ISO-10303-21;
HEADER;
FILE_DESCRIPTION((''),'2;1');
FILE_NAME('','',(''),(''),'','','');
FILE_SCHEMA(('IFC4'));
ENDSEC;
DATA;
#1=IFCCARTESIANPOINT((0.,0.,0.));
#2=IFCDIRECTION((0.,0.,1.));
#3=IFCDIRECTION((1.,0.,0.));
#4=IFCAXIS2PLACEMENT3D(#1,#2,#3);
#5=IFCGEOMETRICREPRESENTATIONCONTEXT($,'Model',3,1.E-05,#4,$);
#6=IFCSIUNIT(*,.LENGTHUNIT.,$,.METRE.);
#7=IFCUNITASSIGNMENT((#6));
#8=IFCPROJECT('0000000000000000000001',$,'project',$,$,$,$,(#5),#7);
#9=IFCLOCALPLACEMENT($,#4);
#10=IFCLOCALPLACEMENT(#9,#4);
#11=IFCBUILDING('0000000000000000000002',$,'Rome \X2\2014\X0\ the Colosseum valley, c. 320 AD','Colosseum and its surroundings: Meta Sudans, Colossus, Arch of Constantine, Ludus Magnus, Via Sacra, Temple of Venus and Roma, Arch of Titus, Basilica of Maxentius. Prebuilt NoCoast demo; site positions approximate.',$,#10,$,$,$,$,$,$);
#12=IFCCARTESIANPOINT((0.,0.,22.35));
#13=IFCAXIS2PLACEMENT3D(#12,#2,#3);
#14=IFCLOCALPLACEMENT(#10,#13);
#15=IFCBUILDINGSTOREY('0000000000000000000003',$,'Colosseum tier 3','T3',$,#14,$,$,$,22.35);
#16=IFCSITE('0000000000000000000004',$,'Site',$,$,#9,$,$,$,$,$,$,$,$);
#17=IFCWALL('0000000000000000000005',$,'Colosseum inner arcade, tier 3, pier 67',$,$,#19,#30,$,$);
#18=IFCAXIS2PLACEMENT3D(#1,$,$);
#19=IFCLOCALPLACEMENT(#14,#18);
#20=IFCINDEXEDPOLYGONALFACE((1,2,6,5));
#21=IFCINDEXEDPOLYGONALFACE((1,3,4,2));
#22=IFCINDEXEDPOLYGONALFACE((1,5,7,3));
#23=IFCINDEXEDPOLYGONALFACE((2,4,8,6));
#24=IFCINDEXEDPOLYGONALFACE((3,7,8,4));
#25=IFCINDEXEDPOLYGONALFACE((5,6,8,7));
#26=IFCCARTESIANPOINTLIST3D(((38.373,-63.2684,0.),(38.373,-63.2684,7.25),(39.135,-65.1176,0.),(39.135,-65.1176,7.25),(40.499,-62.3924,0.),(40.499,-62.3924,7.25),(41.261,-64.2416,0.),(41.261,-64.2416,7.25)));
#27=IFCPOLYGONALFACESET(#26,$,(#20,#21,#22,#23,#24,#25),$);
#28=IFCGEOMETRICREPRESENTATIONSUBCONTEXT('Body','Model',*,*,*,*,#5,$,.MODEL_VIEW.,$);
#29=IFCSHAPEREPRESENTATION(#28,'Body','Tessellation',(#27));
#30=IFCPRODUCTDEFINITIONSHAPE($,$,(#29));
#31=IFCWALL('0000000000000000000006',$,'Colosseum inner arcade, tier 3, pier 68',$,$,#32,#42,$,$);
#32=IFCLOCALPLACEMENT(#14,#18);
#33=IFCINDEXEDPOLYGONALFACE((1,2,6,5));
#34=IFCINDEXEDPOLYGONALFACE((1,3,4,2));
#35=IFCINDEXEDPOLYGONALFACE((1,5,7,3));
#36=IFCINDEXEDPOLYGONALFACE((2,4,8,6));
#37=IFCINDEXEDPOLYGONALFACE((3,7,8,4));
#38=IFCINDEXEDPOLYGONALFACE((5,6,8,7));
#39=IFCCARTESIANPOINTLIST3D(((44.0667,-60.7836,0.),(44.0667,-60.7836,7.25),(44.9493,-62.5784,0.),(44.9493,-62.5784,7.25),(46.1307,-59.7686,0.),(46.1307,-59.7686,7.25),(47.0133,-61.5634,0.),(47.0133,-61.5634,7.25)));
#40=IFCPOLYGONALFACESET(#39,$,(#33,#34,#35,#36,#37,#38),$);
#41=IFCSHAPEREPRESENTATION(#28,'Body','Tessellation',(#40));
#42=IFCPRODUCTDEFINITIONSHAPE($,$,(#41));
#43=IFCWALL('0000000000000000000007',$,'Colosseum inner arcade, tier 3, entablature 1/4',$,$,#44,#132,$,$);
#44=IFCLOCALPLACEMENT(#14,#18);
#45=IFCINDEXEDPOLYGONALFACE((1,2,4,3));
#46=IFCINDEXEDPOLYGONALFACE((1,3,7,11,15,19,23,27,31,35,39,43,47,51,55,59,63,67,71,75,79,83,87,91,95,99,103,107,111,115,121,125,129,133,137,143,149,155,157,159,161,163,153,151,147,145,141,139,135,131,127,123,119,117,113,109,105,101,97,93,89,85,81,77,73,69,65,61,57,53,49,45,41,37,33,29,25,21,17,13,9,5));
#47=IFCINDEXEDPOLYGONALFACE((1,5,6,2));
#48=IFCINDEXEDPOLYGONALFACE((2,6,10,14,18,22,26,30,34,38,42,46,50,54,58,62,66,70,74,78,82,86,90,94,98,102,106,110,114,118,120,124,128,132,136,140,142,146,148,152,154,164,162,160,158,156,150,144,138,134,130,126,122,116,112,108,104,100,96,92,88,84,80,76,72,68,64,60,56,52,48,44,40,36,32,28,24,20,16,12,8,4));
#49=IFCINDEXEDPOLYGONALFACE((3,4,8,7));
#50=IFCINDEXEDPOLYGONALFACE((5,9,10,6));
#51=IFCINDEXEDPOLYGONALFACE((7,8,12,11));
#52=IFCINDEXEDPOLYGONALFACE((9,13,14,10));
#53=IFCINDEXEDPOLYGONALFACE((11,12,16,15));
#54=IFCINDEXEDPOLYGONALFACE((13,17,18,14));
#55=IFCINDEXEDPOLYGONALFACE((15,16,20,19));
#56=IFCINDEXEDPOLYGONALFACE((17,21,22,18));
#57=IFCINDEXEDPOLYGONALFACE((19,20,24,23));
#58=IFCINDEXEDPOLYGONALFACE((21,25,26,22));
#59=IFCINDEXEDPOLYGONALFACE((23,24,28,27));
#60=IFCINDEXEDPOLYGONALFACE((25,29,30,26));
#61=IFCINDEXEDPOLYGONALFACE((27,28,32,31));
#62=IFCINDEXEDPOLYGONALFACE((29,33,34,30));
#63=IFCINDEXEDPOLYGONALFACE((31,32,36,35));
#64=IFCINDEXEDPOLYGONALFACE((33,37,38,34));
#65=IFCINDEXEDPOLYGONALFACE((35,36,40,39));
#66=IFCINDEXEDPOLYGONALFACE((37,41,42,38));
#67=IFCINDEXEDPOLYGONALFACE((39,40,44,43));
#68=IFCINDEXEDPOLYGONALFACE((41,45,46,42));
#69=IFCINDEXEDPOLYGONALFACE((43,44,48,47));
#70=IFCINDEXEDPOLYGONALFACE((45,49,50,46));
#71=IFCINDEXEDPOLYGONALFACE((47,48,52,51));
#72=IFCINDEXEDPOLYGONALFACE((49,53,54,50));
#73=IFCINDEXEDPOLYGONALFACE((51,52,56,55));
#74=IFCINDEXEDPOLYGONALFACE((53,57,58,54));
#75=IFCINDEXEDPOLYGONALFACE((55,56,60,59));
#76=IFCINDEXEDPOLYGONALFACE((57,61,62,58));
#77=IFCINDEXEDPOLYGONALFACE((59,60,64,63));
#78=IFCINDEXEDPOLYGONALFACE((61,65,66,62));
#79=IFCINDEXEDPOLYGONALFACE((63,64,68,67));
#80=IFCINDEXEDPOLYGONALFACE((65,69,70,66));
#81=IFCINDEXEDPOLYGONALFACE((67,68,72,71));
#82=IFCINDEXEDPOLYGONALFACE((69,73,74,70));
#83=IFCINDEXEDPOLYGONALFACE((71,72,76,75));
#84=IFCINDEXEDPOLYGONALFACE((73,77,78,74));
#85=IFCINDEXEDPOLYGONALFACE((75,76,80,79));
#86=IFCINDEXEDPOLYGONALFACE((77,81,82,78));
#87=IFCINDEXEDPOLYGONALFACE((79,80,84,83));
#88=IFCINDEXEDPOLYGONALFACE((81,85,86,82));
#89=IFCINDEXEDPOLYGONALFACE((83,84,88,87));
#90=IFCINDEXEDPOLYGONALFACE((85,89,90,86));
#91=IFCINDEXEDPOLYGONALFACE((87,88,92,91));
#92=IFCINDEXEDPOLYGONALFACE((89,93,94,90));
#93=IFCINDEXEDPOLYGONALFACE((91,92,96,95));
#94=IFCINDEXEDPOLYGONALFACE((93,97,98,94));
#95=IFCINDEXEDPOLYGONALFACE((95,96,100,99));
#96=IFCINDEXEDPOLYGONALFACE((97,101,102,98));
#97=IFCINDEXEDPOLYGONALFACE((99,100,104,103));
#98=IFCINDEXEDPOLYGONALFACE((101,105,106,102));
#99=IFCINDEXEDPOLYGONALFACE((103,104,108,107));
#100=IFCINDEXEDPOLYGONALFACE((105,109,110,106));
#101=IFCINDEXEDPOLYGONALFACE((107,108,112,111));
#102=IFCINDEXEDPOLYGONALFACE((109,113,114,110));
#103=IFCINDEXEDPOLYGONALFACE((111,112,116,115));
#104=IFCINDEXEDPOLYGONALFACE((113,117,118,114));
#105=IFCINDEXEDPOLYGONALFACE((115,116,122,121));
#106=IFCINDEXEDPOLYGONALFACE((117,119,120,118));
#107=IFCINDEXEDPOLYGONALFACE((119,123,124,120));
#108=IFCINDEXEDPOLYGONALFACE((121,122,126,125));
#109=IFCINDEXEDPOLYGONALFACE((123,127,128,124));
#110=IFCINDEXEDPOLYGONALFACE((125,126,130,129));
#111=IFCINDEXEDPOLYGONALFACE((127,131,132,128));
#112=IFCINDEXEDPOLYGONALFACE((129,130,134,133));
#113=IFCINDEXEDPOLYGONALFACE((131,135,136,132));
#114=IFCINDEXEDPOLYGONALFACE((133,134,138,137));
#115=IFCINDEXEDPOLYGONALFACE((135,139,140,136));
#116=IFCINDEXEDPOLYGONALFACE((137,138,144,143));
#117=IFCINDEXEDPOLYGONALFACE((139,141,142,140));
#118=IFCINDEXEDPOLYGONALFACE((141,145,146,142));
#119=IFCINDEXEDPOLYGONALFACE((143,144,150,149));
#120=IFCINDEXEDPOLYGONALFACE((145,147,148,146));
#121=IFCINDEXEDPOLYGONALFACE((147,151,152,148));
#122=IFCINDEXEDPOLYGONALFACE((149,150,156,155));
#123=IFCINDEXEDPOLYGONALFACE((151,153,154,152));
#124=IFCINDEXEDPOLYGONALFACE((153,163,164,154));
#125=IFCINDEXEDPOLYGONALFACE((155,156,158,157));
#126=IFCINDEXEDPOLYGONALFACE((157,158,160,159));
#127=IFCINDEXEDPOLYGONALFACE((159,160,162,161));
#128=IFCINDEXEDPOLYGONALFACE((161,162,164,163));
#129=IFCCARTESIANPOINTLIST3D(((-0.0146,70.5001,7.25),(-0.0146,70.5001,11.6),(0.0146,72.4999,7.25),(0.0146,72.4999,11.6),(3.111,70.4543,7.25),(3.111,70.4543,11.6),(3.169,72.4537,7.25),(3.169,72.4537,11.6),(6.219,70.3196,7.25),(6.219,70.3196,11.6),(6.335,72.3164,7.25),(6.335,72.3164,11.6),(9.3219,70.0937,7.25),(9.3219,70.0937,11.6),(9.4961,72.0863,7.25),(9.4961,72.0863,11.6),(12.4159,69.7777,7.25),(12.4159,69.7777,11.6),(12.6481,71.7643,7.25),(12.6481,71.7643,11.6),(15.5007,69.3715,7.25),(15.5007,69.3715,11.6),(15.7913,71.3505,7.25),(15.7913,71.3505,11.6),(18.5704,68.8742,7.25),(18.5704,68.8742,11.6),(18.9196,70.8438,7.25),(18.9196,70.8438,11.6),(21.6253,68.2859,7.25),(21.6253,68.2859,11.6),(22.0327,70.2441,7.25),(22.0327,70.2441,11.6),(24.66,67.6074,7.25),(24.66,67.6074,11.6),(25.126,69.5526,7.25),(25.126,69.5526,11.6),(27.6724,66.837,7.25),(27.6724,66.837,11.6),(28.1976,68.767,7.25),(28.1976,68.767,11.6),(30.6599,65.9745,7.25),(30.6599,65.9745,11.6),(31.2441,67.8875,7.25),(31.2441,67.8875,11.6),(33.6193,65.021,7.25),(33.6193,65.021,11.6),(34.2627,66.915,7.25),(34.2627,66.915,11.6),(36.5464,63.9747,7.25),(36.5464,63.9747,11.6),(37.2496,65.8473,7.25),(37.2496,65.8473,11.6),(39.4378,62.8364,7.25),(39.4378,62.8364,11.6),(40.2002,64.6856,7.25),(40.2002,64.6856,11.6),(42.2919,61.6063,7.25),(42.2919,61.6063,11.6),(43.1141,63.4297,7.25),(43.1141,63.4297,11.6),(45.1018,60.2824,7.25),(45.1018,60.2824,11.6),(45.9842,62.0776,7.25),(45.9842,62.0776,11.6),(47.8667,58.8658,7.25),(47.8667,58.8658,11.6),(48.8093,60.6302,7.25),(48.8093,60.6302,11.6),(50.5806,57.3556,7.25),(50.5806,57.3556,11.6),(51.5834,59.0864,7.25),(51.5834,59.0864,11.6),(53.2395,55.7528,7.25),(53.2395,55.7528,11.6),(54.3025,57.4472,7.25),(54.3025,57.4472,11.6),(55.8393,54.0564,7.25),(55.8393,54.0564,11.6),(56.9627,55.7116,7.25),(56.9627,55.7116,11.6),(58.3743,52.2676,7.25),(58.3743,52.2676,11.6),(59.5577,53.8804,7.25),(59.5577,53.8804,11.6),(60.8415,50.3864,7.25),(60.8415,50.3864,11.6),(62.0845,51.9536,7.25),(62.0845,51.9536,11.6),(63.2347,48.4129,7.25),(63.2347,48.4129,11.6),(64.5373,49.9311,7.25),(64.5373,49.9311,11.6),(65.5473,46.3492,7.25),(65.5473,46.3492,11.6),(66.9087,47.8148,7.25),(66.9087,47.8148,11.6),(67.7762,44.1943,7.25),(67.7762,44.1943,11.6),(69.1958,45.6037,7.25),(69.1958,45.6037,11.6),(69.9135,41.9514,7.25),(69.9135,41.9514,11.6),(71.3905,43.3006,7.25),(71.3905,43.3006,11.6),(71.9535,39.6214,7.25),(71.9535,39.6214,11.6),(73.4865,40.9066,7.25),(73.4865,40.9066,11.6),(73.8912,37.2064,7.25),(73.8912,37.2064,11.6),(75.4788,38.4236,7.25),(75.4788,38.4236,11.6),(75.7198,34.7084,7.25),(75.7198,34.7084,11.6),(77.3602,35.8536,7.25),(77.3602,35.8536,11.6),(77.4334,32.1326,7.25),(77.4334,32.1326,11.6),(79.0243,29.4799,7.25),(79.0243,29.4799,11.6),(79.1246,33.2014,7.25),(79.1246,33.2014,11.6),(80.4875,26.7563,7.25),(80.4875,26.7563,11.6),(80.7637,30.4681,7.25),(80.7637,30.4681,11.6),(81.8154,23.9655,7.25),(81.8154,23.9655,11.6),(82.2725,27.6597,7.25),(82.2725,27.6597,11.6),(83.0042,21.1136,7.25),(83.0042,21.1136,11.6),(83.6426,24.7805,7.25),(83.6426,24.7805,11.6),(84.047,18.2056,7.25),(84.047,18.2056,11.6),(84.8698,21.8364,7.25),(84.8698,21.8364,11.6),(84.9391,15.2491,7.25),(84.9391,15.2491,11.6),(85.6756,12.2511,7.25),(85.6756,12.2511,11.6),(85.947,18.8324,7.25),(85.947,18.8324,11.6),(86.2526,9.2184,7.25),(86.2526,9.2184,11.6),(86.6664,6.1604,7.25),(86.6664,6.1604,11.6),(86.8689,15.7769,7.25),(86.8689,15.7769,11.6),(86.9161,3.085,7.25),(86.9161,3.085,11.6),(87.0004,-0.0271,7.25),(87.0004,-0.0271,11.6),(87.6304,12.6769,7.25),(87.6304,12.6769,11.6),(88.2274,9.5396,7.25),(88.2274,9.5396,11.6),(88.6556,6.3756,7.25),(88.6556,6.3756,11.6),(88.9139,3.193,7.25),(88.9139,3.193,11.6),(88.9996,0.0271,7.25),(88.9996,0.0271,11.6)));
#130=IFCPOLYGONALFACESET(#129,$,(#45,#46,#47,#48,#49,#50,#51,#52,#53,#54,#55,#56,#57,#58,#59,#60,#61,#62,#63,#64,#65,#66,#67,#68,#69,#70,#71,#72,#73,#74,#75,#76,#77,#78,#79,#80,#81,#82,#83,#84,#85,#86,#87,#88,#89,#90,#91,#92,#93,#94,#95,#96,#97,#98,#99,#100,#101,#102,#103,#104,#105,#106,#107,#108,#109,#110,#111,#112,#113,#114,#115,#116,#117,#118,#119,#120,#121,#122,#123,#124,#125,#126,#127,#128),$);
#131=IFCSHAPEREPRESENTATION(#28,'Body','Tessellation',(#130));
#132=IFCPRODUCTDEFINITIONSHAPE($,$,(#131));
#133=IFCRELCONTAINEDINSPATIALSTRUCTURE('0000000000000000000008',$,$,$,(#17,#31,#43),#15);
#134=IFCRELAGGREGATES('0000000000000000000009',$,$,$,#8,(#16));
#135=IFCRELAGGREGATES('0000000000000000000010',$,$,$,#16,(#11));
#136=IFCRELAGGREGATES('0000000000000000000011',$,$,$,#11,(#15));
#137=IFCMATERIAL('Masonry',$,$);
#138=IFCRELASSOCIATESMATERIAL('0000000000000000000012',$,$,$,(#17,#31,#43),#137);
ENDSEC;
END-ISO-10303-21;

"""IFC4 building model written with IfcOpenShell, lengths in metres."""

from ifc_helpers import new_model, si_unit, frame, origin_with_axes, place, context, subcontext, project, spatial, polyline, indexed_curve, outline, extrude, material, element, save


model = new_model("IFC4")

# Units and contexts
model_context = context("Model", 3, precision=1e-05, world=origin_with_axes())
body_context = subcontext(model_context, "Body", "Model", "MODEL_VIEW")
ifc_project = project(units=[si_unit("LENGTHUNIT", "METRE")], contexts=[model_context])

# Site, building, storey
site_placement = place(None, origin_with_axes())
site = spatial("IfcSite", under=ifc_project, at=site_placement, Name="Site")
building_placement = place(site_placement, origin_with_axes())
building = spatial("IfcBuilding", under=site, at=building_placement, Name="Rome — the Colosseum valley, c. 320 AD", Description="Colosseum and its surroundings: Meta Sudans, Colossus, Arch of Constantine, Ludus Magnus, Via Sacra, Temple of Venus and Roma, Arch of Titus, Basilica of Maxentius. Prebuilt NoCoast demo; site positions approximate.")
storey_placement = place(building_placement, frame((0.0, 0.0, 22.35), z_axis=(0.0, 0.0, 1.0), x_axis=(1.0, 0.0, 0.0)))
storey = spatial("IfcBuildingStorey", under=building, at=storey_placement, Name="Colosseum tier 3", Description="T3", Elevation=22.35)

# Walls
ifc_material_1 = material(Name="Masonry")
wall_1_placement = place(storey_placement, frame((38.754, -64.193, 0.0), z_axis=(0.0, 0.0, 1.0), x_axis=(0.924588, 0.380969, 0.0)))
element("IfcWall", 1, at=wall_1_placement, inside=storey, material=ifc_material_1, Name="Colosseum inner arcade, tier 3, pier 67", context=body_context, shape_type="SweptSolid", body=[
    extrude(outline(indexed_curve([(0.0, 0.0), (0.0, 2.0), (2.2994, 2.0), (2.2994, 0.0), (0.0, 0.0)], self_intersect=False)), frame((0.0, -1.0, 0.0), z_axis=(0.0, 0.0, 1.0), x_axis=(1.0, 0.0, 0.0)), (0.0, 0.0, 1.0), 7.25),
])
wall_2_placement = place(storey_placement, frame((44.508, -61.681, 0.0), z_axis=(0.0, 0.0, 1.0), x_axis=(0.897364, 0.441291, 0.0)))
element("IfcWall", 2, at=wall_2_placement, inside=storey, material=ifc_material_1, Name="Colosseum inner arcade, tier 3, pier 68", context=body_context, shape_type="SweptSolid", body=[
    extrude(outline(indexed_curve([(0.0, 0.0), (0.0, 2.0), (2.3001, 2.0), (2.3001, 0.0), (0.0, 0.0)], self_intersect=False)), frame((0.0, -1.0, 0.0), z_axis=(0.0, 0.0, 1.0), x_axis=(1.0, 0.0, 0.0)), (0.0, 0.0, 1.0), 7.25),
])
wall_3_placement = place(storey_placement, frame((0.0, 0.0, 7.25), z_axis=(0.0, 0.0, 1.0), x_axis=(1.0, 0.0, 0.0)))
element("IfcWall", 3, at=wall_3_placement, inside=storey, material=ifc_material_1, Name="Colosseum inner arcade, tier 3, entablature 1/4", context=body_context, shape_type="SweptSolid", body=[
    extrude(outline(polyline([(86.9161, 3.085), (86.6664, 6.1604), (86.2526, 9.2184), (85.6756, 12.2511), (84.9391, 15.2491), (84.047, 18.2056), (83.0042, 21.1136), (81.8154, 23.9655), (80.4875, 26.7563), (79.0243, 29.4799), (77.4334, 32.1326), (75.7198, 34.7084), (73.8912, 37.2064), (71.9535, 39.6214), (69.9135, 41.9514), (67.7762, 44.1943), (65.5473, 46.3492), (63.2347, 48.4129), (60.8415, 50.3864), (58.3743, 52.2676), (55.8393, 54.0564), (53.2395, 55.7528), (50.5806, 57.3556), (47.8667, 58.8658), (45.1018, 60.2824), (42.2919, 61.6063), (39.4378, 62.8364), (36.5464, 63.9747), (33.6193, 65.021), (30.6599, 65.9745), (27.6724, 66.837), (24.66, 67.6074), (21.6253, 68.2859), (18.5704, 68.8742), (15.5007, 69.3715), (12.4159, 69.7777), (9.3219, 70.0937), (6.219, 70.3196), (3.111, 70.4543), (-0.0146, 70.5001), (0.0146, 72.4999), (3.169, 72.4537), (6.335, 72.3164), (9.4961, 72.0863), (12.6481, 71.7643), (15.7913, 71.3505), (18.9196, 70.8438), (22.0327, 70.2441), (25.126, 69.5526), (28.1976, 68.767), (31.2441, 67.8875), (34.2627, 66.915), (37.2496, 65.8473), (40.2002, 64.6856), (43.1141, 63.4297), (45.9842, 62.0776), (48.8093, 60.6302), (51.5834, 59.0864), (54.3025, 57.4472), (56.9627, 55.7116), (59.5577, 53.8804), (62.0845, 51.9536), (64.5373, 49.9311), (66.9087, 47.8148), (69.1958, 45.6037), (71.3905, 43.3006), (73.4865, 40.9066), (75.4788, 38.4236), (77.3602, 35.8536), (79.1246, 33.2014), (80.7637, 30.4681), (82.2725, 27.6597), (83.6426, 24.7805), (84.8698, 21.8364), (85.947, 18.8324), (86.8689, 15.7769), (87.6304, 12.6769), (88.2274, 9.5396), (88.6556, 6.3756), (88.9139, 3.193), (88.9996, 0.0271), (87.0004, -0.0271), (86.9161, 3.085)])), origin_with_axes(), (0.0, 0.0, 1.0), 4.35),
])

save(model, "model.ifc")
